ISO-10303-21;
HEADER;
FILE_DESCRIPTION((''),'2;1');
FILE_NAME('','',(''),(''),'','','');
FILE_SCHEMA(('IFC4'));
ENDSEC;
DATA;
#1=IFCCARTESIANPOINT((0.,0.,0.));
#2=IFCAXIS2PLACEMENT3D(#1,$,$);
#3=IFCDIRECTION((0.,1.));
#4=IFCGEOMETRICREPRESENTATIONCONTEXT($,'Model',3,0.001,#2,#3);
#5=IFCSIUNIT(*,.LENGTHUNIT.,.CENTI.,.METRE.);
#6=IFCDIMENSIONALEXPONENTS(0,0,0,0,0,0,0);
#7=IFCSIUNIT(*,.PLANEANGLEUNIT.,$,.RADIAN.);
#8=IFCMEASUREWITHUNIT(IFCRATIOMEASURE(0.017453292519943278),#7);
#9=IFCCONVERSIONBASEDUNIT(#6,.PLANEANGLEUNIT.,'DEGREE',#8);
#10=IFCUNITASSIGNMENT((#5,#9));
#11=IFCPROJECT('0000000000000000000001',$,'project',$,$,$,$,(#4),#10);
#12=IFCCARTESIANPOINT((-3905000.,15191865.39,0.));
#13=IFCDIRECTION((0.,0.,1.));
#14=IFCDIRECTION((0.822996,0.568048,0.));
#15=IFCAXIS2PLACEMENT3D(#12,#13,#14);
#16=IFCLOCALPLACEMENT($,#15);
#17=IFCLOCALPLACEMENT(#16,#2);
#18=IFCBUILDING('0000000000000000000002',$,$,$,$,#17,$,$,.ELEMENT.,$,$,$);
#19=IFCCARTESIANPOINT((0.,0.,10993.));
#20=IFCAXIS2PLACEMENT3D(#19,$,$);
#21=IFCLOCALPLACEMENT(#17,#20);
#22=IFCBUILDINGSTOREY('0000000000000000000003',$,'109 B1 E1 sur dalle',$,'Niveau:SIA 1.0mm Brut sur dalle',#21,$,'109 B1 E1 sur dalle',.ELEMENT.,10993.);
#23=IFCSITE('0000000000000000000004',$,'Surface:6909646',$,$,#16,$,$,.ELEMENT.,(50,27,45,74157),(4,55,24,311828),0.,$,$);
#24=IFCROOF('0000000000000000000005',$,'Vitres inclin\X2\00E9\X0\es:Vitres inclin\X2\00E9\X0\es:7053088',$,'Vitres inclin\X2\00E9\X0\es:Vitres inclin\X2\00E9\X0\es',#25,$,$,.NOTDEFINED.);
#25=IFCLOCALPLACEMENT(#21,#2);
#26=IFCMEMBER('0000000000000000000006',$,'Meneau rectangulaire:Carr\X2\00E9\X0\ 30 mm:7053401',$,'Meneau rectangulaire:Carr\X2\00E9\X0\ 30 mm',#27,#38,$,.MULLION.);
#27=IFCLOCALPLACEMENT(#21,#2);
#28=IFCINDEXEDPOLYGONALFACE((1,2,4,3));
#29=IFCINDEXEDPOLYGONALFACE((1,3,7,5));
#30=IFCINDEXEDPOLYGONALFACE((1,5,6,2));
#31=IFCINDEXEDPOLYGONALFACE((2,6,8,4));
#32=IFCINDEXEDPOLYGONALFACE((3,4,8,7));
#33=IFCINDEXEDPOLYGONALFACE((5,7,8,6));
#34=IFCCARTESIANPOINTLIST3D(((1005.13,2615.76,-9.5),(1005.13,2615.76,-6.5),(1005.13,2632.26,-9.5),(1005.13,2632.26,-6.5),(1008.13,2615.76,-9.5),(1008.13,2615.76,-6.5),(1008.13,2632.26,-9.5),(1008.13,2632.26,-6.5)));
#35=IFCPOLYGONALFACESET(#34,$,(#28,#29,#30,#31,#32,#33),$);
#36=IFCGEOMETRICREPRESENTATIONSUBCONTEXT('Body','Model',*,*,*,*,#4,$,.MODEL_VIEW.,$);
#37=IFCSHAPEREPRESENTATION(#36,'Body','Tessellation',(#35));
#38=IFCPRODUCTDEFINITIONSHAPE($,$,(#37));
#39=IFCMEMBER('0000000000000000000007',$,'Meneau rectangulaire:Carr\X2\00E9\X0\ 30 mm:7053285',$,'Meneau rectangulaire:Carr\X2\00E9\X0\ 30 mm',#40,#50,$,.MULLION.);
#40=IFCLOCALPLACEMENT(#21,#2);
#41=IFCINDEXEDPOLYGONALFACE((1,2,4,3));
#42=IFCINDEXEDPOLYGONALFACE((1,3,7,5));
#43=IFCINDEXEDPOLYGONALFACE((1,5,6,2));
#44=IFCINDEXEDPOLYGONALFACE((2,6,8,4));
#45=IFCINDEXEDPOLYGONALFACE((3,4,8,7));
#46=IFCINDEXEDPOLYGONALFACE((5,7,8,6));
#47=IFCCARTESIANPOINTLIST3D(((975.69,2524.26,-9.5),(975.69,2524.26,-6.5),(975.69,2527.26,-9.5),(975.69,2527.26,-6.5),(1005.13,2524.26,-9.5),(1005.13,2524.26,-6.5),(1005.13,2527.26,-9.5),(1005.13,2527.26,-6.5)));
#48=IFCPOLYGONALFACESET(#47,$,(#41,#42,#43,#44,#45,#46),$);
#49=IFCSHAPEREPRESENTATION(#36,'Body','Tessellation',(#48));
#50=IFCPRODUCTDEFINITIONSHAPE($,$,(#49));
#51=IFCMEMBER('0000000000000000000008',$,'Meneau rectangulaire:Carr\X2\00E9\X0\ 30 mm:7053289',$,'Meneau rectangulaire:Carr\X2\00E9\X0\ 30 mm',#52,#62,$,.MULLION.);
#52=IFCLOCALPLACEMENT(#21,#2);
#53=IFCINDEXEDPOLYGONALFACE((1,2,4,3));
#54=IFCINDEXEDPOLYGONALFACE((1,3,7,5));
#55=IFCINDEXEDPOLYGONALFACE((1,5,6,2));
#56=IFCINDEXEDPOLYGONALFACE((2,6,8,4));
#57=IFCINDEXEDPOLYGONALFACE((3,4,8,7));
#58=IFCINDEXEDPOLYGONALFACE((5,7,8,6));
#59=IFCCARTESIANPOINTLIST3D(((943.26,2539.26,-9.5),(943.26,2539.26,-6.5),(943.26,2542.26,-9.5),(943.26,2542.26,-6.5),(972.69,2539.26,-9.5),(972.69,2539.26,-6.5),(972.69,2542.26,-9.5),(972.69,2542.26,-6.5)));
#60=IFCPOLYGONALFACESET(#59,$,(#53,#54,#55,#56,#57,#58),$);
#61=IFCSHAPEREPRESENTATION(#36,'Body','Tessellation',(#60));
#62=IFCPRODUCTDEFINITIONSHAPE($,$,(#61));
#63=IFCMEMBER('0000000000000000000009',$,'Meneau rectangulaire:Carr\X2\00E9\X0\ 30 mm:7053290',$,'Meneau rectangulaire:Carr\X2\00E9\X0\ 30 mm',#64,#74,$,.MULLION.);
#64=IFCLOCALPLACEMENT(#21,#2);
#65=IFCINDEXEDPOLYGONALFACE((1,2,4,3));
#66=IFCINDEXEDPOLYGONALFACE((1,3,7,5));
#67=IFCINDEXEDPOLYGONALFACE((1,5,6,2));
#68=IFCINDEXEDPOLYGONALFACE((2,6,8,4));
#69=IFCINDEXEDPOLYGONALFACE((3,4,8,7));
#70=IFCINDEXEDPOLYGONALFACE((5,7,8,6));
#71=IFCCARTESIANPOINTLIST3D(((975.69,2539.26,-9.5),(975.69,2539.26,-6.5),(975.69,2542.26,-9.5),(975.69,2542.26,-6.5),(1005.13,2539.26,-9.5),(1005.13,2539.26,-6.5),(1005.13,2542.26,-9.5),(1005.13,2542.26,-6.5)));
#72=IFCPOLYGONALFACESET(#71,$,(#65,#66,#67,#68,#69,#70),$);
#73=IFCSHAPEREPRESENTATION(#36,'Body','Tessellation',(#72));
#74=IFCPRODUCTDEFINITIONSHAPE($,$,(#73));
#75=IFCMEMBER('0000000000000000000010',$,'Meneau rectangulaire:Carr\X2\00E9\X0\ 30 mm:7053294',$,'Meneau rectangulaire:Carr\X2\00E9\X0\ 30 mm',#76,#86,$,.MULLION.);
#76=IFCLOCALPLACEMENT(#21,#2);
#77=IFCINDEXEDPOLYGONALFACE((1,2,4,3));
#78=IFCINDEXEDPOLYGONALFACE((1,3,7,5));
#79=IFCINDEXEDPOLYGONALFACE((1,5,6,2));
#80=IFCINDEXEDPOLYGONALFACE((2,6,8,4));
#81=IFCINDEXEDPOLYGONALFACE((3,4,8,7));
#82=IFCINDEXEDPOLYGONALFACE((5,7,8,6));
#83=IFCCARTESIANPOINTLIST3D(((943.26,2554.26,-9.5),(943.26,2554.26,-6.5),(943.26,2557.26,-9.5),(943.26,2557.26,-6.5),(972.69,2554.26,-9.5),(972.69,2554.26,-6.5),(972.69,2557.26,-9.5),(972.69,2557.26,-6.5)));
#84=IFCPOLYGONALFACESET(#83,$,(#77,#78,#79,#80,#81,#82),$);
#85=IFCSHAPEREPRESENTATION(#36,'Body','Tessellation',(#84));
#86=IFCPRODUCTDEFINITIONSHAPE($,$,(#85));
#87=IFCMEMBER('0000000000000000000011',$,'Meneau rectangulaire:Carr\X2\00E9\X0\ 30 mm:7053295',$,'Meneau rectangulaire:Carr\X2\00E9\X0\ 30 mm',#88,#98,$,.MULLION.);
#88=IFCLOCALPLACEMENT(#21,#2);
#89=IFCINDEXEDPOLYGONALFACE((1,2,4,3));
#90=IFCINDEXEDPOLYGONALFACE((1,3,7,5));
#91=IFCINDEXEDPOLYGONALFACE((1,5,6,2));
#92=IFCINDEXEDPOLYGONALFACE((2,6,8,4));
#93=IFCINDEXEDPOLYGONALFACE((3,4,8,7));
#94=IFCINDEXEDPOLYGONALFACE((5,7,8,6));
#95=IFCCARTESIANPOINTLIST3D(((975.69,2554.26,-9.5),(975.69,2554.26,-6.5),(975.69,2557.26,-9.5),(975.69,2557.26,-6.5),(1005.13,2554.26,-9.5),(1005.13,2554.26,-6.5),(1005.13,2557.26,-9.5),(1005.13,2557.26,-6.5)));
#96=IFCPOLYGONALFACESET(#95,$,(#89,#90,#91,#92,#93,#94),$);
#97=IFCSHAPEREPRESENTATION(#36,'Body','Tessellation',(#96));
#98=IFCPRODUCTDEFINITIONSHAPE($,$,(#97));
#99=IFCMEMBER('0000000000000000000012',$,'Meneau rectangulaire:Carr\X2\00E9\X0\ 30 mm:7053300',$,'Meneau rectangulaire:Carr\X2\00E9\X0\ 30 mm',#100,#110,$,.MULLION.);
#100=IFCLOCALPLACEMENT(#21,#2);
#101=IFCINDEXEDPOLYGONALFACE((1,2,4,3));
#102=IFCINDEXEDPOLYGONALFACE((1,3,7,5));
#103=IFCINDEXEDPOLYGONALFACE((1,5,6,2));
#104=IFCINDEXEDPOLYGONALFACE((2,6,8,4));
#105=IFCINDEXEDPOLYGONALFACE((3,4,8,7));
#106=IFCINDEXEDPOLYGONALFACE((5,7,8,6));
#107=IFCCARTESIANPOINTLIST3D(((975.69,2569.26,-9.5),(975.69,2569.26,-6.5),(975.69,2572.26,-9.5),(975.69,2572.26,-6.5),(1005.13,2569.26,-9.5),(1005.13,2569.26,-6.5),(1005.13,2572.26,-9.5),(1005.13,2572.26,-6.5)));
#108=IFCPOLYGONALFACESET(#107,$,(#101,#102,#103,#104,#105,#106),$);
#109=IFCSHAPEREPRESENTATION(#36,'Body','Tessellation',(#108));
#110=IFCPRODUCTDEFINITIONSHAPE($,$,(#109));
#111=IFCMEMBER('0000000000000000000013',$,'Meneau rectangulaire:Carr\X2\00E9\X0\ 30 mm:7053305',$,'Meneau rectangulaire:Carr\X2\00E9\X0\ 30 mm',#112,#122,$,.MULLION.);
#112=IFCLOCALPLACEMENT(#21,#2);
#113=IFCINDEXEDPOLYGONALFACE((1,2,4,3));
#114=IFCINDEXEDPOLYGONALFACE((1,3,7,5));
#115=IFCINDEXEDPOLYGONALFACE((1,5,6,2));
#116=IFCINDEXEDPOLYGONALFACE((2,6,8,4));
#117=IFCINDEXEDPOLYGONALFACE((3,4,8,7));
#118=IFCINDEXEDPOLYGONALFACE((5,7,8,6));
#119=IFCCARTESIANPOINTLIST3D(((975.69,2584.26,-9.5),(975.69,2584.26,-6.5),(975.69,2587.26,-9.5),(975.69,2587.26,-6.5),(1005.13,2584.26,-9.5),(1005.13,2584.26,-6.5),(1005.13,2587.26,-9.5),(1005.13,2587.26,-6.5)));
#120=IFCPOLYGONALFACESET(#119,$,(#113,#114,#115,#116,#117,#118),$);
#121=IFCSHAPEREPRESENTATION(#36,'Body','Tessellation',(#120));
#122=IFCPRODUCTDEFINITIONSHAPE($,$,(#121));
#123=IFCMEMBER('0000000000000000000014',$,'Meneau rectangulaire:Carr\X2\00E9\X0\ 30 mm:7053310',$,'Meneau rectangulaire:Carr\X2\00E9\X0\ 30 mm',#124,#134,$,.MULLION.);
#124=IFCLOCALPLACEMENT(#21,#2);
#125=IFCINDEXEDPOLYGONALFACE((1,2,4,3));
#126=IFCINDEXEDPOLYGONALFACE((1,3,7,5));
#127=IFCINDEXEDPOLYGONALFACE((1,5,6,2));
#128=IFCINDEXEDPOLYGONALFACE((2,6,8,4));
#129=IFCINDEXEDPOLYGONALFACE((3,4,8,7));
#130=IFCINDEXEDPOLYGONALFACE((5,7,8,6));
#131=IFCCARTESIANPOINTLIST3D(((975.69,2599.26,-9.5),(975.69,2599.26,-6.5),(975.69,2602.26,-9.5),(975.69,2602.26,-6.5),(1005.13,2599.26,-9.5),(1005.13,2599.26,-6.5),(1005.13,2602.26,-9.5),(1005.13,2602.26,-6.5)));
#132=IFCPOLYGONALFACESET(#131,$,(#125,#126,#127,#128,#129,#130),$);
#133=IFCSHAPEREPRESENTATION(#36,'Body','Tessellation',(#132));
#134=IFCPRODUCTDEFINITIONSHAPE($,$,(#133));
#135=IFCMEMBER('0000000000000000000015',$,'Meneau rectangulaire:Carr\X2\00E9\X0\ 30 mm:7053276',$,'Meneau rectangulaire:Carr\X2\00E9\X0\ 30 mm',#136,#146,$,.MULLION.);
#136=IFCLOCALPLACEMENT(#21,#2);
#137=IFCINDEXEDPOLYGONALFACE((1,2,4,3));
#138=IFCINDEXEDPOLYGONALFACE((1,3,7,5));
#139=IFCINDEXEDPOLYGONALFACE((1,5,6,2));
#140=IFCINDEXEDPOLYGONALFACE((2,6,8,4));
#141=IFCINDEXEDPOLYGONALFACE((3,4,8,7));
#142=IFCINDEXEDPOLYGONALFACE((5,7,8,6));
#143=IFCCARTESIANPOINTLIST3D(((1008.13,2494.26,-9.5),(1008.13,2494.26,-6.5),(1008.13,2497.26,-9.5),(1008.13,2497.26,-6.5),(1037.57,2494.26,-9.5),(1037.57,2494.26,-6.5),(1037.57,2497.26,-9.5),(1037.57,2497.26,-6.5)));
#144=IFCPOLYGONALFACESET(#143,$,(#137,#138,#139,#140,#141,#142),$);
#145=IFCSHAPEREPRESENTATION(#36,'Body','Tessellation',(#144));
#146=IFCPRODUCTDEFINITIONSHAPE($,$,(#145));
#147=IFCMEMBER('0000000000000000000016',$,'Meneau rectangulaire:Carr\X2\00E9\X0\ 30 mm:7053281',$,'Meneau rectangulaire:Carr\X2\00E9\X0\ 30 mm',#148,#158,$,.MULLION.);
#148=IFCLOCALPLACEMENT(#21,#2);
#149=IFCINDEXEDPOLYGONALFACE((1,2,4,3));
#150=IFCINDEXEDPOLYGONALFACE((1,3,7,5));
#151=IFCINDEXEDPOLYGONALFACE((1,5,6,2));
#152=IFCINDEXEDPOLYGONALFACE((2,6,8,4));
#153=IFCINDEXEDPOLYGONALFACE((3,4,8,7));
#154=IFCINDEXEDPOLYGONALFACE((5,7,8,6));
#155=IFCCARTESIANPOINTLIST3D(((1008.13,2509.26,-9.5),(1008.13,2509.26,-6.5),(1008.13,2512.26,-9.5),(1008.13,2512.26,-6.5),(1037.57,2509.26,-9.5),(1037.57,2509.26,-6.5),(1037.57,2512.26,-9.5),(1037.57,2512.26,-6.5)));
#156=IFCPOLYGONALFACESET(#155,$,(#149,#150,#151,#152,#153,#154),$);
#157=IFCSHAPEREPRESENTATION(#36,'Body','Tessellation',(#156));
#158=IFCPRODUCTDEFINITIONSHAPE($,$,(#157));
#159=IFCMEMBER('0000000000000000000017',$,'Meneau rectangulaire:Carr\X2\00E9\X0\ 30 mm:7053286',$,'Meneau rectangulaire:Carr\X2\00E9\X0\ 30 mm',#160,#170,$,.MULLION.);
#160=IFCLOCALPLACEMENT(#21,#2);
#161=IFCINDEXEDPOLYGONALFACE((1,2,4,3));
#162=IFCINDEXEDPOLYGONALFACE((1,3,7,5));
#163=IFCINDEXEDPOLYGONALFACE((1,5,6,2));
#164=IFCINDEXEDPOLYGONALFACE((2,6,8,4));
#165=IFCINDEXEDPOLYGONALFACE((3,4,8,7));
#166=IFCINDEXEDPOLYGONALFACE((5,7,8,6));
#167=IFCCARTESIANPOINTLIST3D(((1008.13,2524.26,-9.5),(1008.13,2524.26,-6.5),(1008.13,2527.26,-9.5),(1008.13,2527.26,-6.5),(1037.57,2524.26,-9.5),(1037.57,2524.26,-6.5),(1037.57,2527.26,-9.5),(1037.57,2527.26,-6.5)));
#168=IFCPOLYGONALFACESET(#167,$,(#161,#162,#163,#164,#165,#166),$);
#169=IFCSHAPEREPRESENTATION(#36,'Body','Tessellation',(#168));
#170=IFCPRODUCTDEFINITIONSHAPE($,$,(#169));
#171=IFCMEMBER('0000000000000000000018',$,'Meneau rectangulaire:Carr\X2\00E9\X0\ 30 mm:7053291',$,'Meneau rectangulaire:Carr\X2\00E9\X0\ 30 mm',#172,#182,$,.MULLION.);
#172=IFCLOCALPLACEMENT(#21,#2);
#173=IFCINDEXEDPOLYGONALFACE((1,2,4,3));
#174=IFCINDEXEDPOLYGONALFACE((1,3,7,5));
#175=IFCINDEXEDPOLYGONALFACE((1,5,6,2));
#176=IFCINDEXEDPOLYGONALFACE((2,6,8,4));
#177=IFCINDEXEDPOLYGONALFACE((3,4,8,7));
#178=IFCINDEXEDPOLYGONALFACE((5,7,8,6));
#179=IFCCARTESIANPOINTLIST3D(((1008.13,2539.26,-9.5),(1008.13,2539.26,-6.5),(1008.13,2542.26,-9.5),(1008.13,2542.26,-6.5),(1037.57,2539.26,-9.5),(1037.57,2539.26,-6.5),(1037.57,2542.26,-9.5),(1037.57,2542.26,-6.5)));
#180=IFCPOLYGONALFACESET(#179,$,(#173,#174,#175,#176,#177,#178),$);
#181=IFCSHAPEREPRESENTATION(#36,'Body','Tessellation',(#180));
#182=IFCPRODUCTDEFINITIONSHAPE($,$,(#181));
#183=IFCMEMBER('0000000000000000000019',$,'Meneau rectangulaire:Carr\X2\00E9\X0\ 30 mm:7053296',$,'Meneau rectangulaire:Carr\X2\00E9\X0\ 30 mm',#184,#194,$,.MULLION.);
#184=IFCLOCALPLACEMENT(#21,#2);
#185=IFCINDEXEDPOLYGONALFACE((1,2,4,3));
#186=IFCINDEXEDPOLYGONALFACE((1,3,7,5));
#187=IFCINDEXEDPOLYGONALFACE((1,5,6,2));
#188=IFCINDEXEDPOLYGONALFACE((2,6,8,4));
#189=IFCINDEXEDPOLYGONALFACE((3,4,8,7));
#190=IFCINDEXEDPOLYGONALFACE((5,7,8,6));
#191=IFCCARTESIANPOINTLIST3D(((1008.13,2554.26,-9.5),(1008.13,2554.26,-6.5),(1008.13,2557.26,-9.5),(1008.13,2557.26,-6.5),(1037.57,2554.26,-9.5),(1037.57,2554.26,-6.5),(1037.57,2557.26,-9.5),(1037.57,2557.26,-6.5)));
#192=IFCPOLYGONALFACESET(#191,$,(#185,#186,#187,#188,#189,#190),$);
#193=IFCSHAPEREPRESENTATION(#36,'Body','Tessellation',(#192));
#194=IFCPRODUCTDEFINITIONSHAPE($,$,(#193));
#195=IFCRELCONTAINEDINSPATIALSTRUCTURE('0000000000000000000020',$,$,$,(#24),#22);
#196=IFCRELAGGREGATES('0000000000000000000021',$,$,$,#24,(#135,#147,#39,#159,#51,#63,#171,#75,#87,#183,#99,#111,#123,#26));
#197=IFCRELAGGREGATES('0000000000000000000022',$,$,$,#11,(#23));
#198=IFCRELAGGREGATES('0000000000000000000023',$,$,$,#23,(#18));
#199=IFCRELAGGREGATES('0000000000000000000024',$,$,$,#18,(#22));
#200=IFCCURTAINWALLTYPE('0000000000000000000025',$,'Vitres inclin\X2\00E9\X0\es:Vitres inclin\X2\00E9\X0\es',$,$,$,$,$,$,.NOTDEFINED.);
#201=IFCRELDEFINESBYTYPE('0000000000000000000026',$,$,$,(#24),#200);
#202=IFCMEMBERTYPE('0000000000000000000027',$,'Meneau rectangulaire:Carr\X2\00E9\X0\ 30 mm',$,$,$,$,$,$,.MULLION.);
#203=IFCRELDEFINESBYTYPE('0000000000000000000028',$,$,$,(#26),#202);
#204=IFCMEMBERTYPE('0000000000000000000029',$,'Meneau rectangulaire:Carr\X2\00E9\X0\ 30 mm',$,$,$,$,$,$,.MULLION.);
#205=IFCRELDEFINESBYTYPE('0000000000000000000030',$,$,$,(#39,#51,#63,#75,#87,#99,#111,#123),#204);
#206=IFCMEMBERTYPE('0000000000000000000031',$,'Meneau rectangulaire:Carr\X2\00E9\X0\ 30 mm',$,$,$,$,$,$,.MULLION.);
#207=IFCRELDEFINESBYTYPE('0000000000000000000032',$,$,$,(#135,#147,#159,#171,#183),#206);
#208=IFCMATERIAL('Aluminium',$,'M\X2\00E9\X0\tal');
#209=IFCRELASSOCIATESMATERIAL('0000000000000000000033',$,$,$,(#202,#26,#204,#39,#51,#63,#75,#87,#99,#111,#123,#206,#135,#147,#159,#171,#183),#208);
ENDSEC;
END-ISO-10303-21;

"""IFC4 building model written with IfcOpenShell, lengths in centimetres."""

from ifc_helpers import new_model, entity, si_unit, converted_unit, direction, frame, origin, place, context, subcontext, project, spatial, indexed_curve, outline, extrude, source, transform, mapped, material, type_object, type_shapes, element, aggregate, save


model = new_model("IFC4")

# Units and contexts
model_context = context("Model", 3, precision=0.001, world=origin(), true_north=direction((0.0, 1.0)))
body_context = subcontext(model_context, "Body", "Model", "MODEL_VIEW")
ifc_project = project(units=[si_unit("LENGTHUNIT", "METRE", prefix="CENTI"), converted_unit("PLANEANGLEUNIT", "DEGREE", entity("IfcRatioMeasure", 0.017453292519943278), si_unit("PLANEANGLEUNIT", "RADIAN"), dimensions=[0, 0, 0, 0, 0, 0, 0])], contexts=[model_context])

# Site, building, storey
site_placement = place(None, frame((-3905000.0, 15191865.39, 0.0), z_axis=(0.0, 0.0, 1.0), x_axis=(0.822996, 0.568048, 0.0)))
site = spatial("IfcSite", under=ifc_project, at=site_placement, Name="Surface:6909646", CompositionType="ELEMENT", RefLatitude=(50, 27, 45, 74157), RefLongitude=(4, 55, 24, 311828), RefElevation=0.0)
building_placement = place(site_placement, origin())
building = spatial("IfcBuilding", under=site, at=building_placement, CompositionType="ELEMENT")
storey_placement = place(building_placement, frame((0.0, 0.0, 10993.0)))
storey = spatial("IfcBuildingStorey", under=building, at=storey_placement, Name="109 B1 E1 sur dalle", ObjectType="Niveau:SIA 1.0mm Brut sur dalle", LongName="109 B1 E1 sur dalle", CompositionType="ELEMENT", Elevation=10993.0)

# Roof, members
curtain_wall_type = type_object("IfcCurtainWallType", Name="Vitres inclinées:Vitres inclinées", PredefinedType="NOTDEFINED")
roof_placement = place(storey_placement, frame((0.0, 0.0, -10993.0)))
roof = element("IfcRoof", 1, at=roof_placement, inside=storey, type_object=curtain_wall_type, Name="Vitres inclinées:Vitres inclinées:7053088", ObjectType="Vitres inclinées:Vitres inclinées", PredefinedType="NOTDEFINED")
ifc_material = material(Name="Aluminium", Category="Métal")
member_type_1 = type_object("IfcMemberType", Name="Meneau rectangulaire:Carré 30 mm", PredefinedType="MULLION", material=ifc_material)
shared_shape_1 = source(origin(), body_context, "Body", "SweptSolid", [
    extrude(outline(indexed_curve([(-1.5, -1.5), (1.5, -1.5), (1.5, 1.5), (-1.5, 1.5), (-1.5, -1.5)], self_intersect=False)), frame((0.0, 0.0, -16.5), z_axis=(0.0, 0.0, 1.0), x_axis=(0.0, -1.0, 0.0)), (0.0, 0.0, 1.0), 16.5),
])
type_shapes(member_type_1, [shared_shape_1])
member_1_placement = place(roof_placement, frame((1006.63, 2632.26, 10985.0), z_axis=(0.0, 1.0, 0.0), x_axis=(1.0, 0.0, 0.0)))
member_1 = element("IfcMember", 2, at=member_1_placement, type_object=member_type_1, material=ifc_material, Name="Meneau rectangulaire:Carré 30 mm:7053401", ObjectType="Meneau rectangulaire:Carré 30 mm", PredefinedType="MULLION", context=body_context, shape_type="MappedRepresentation", body=[
    mapped(shared_shape_1, transform((0.0, 0.0, 0.0), scale=1.0)),
])
member_type_2 = type_object("IfcMemberType", Name="Meneau rectangulaire:Carré 30 mm", PredefinedType="MULLION", material=ifc_material)
shared_shape_2 = source(origin(), body_context, "Body", "SweptSolid", [
    extrude(outline(indexed_curve([(-1.5, -1.5), (1.5, -1.5), (1.5, 1.5), (-1.5, 1.5), (-1.5, -1.5)], self_intersect=False)), frame((0.0, 0.0, -29.44), z_axis=(0.0, 0.0, 1.0), x_axis=(0.0, -1.0, 0.0)), (0.0, 0.0, 1.0), 29.44),
])
type_shapes(member_type_2, [shared_shape_2])
member_2_placement = place(roof_placement, frame((975.69, 2525.76, 10985.0), z_axis=(-1.0, 0.0, 0.0), x_axis=(0.0, 1.0, 0.0)))
member_2 = element("IfcMember", 3, at=member_2_placement, type_object=member_type_2, material=ifc_material, Name="Meneau rectangulaire:Carré 30 mm:7053285", ObjectType="Meneau rectangulaire:Carré 30 mm", PredefinedType="MULLION", context=body_context, shape_type="MappedRepresentation", body=[
    mapped(shared_shape_2, transform((0.0, 0.0, 0.0), scale=1.0)),
])
member_3_placement = place(roof_placement, frame((943.26, 2540.76, 10985.0), z_axis=(-1.0, 0.0, 0.0), x_axis=(0.0, 1.0, 0.0)))
member_3 = element("IfcMember", 4, at=member_3_placement, type_object=member_type_2, material=ifc_material, Name="Meneau rectangulaire:Carré 30 mm:7053289", ObjectType="Meneau rectangulaire:Carré 30 mm", PredefinedType="MULLION", context=body_context, shape_type="MappedRepresentation", body=[
    mapped(shared_shape_2, transform((0.0, 0.0, 0.0), scale=1.0)),
])
member_4_placement = place(roof_placement, frame((975.69, 2540.76, 10985.0), z_axis=(-1.0, 0.0, 0.0), x_axis=(0.0, 1.0, 0.0)))
member_4 = element("IfcMember", 5, at=member_4_placement, type_object=member_type_2, material=ifc_material, Name="Meneau rectangulaire:Carré 30 mm:7053290", ObjectType="Meneau rectangulaire:Carré 30 mm", PredefinedType="MULLION", context=body_context, shape_type="MappedRepresentation", body=[
    mapped(shared_shape_2, transform((0.0, 0.0, 0.0), scale=1.0)),
])
member_5_placement = place(roof_placement, frame((943.26, 2555.76, 10985.0), z_axis=(-1.0, 0.0, 0.0), x_axis=(0.0, 1.0, 0.0)))
member_5 = element("IfcMember", 6, at=member_5_placement, type_object=member_type_2, material=ifc_material, Name="Meneau rectangulaire:Carré 30 mm:7053294", ObjectType="Meneau rectangulaire:Carré 30 mm", PredefinedType="MULLION", context=body_context, shape_type="MappedRepresentation", body=[
    mapped(shared_shape_2, transform((0.0, 0.0, 0.0), scale=1.0)),
])
member_6_placement = place(roof_placement, frame((975.69, 2555.76, 10985.0), z_axis=(-1.0, 0.0, 0.0), x_axis=(0.0, 1.0, 0.0)))
member_6 = element("IfcMember", 7, at=member_6_placement, type_object=member_type_2, material=ifc_material, Name="Meneau rectangulaire:Carré 30 mm:7053295", ObjectType="Meneau rectangulaire:Carré 30 mm", PredefinedType="MULLION", context=body_context, shape_type="MappedRepresentation", body=[
    mapped(shared_shape_2, transform((0.0, 0.0, 0.0), scale=1.0)),
])
member_7_placement = place(roof_placement, frame((975.69, 2570.76, 10985.0), z_axis=(-1.0, 0.0, 0.0), x_axis=(0.0, 1.0, 0.0)))
member_7 = element("IfcMember", 8, at=member_7_placement, type_object=member_type_2, material=ifc_material, Name="Meneau rectangulaire:Carré 30 mm:7053300", ObjectType="Meneau rectangulaire:Carré 30 mm", PredefinedType="MULLION", context=body_context, shape_type="MappedRepresentation", body=[
    mapped(shared_shape_2, transform((0.0, 0.0, 0.0), scale=1.0)),
])
member_8_placement = place(roof_placement, frame((975.69, 2585.76, 10985.0), z_axis=(-1.0, 0.0, 0.0), x_axis=(0.0, 1.0, 0.0)))
member_8 = element("IfcMember", 9, at=member_8_placement, type_object=member_type_2, material=ifc_material, Name="Meneau rectangulaire:Carré 30 mm:7053305", ObjectType="Meneau rectangulaire:Carré 30 mm", PredefinedType="MULLION", context=body_context, shape_type="MappedRepresentation", body=[
    mapped(shared_shape_2, transform((0.0, 0.0, 0.0), scale=1.0)),
])
member_9_placement = place(roof_placement, frame((975.69, 2600.76, 10985.0), z_axis=(-1.0, 0.0, 0.0), x_axis=(0.0, 1.0, 0.0)))
member_9 = element("IfcMember", 10, at=member_9_placement, type_object=member_type_2, material=ifc_material, Name="Meneau rectangulaire:Carré 30 mm:7053310", ObjectType="Meneau rectangulaire:Carré 30 mm", PredefinedType="MULLION", context=body_context, shape_type="MappedRepresentation", body=[
    mapped(shared_shape_2, transform((0.0, 0.0, 0.0), scale=1.0)),
])
member_type_3 = type_object("IfcMemberType", Name="Meneau rectangulaire:Carré 30 mm", PredefinedType="MULLION", material=ifc_material)
shared_shape_3 = source(origin(), body_context, "Body", "SweptSolid", [
    extrude(outline(indexed_curve([(-1.5, -1.5), (1.5, -1.5), (1.5, 1.5), (-1.5, 1.5), (-1.5, -1.5)], self_intersect=False)), frame((0.0, 0.0, -29.44), z_axis=(0.0, 0.0, 1.0), x_axis=(0.0, -1.0, 0.0)), (0.0, 0.0, 1.0), 29.44),
])
type_shapes(member_type_3, [shared_shape_3])
member_10_placement = place(roof_placement, frame((1008.13, 2495.76, 10985.0), z_axis=(-1.0, 0.0, 0.0), x_axis=(0.0, 1.0, 0.0)))
member_10 = element("IfcMember", 11, at=member_10_placement, type_object=member_type_3, material=ifc_material, Name="Meneau rectangulaire:Carré 30 mm:7053276", ObjectType="Meneau rectangulaire:Carré 30 mm", PredefinedType="MULLION", context=body_context, shape_type="MappedRepresentation", body=[
    mapped(shared_shape_3, transform((0.0, 0.0, 0.0), scale=1.0)),
])
member_11_placement = place(roof_placement, frame((1008.13, 2510.76, 10985.0), z_axis=(-1.0, 0.0, 0.0), x_axis=(0.0, 1.0, 0.0)))
member_11 = element("IfcMember", 12, at=member_11_placement, type_object=member_type_3, material=ifc_material, Name="Meneau rectangulaire:Carré 30 mm:7053281", ObjectType="Meneau rectangulaire:Carré 30 mm", PredefinedType="MULLION", context=body_context, shape_type="MappedRepresentation", body=[
    mapped(shared_shape_3, transform((0.0, 0.0, 0.0), scale=1.0)),
])
member_12_placement = place(roof_placement, frame((1008.13, 2525.76, 10985.0), z_axis=(-1.0, 0.0, 0.0), x_axis=(0.0, 1.0, 0.0)))
member_12 = element("IfcMember", 13, at=member_12_placement, type_object=member_type_3, material=ifc_material, Name="Meneau rectangulaire:Carré 30 mm:7053286", ObjectType="Meneau rectangulaire:Carré 30 mm", PredefinedType="MULLION", context=body_context, shape_type="MappedRepresentation", body=[
    mapped(shared_shape_3, transform((0.0, 0.0, 0.0), scale=1.0)),
])
member_13_placement = place(roof_placement, frame((1008.13, 2540.76, 10985.0), z_axis=(-1.0, 0.0, 0.0), x_axis=(0.0, 1.0, 0.0)))
member_13 = element("IfcMember", 14, at=member_13_placement, type_object=member_type_3, material=ifc_material, Name="Meneau rectangulaire:Carré 30 mm:7053291", ObjectType="Meneau rectangulaire:Carré 30 mm", PredefinedType="MULLION", context=body_context, shape_type="MappedRepresentation", body=[
    mapped(shared_shape_3, transform((0.0, 0.0, 0.0), scale=1.0)),
])
member_14_placement = place(roof_placement, frame((1008.13, 2555.76, 10985.0), z_axis=(-1.0, 0.0, 0.0), x_axis=(0.0, 1.0, 0.0)))
member_14 = element("IfcMember", 15, at=member_14_placement, type_object=member_type_3, material=ifc_material, Name="Meneau rectangulaire:Carré 30 mm:7053296", ObjectType="Meneau rectangulaire:Carré 30 mm", PredefinedType="MULLION", context=body_context, shape_type="MappedRepresentation", body=[
    mapped(shared_shape_3, transform((0.0, 0.0, 0.0), scale=1.0)),
])
aggregate(roof, [member_10, member_11, member_2, member_12, member_3, member_4, member_13, member_5, member_6, member_14, member_7, member_8, member_9, member_1])

save(model, "model.ifc")
